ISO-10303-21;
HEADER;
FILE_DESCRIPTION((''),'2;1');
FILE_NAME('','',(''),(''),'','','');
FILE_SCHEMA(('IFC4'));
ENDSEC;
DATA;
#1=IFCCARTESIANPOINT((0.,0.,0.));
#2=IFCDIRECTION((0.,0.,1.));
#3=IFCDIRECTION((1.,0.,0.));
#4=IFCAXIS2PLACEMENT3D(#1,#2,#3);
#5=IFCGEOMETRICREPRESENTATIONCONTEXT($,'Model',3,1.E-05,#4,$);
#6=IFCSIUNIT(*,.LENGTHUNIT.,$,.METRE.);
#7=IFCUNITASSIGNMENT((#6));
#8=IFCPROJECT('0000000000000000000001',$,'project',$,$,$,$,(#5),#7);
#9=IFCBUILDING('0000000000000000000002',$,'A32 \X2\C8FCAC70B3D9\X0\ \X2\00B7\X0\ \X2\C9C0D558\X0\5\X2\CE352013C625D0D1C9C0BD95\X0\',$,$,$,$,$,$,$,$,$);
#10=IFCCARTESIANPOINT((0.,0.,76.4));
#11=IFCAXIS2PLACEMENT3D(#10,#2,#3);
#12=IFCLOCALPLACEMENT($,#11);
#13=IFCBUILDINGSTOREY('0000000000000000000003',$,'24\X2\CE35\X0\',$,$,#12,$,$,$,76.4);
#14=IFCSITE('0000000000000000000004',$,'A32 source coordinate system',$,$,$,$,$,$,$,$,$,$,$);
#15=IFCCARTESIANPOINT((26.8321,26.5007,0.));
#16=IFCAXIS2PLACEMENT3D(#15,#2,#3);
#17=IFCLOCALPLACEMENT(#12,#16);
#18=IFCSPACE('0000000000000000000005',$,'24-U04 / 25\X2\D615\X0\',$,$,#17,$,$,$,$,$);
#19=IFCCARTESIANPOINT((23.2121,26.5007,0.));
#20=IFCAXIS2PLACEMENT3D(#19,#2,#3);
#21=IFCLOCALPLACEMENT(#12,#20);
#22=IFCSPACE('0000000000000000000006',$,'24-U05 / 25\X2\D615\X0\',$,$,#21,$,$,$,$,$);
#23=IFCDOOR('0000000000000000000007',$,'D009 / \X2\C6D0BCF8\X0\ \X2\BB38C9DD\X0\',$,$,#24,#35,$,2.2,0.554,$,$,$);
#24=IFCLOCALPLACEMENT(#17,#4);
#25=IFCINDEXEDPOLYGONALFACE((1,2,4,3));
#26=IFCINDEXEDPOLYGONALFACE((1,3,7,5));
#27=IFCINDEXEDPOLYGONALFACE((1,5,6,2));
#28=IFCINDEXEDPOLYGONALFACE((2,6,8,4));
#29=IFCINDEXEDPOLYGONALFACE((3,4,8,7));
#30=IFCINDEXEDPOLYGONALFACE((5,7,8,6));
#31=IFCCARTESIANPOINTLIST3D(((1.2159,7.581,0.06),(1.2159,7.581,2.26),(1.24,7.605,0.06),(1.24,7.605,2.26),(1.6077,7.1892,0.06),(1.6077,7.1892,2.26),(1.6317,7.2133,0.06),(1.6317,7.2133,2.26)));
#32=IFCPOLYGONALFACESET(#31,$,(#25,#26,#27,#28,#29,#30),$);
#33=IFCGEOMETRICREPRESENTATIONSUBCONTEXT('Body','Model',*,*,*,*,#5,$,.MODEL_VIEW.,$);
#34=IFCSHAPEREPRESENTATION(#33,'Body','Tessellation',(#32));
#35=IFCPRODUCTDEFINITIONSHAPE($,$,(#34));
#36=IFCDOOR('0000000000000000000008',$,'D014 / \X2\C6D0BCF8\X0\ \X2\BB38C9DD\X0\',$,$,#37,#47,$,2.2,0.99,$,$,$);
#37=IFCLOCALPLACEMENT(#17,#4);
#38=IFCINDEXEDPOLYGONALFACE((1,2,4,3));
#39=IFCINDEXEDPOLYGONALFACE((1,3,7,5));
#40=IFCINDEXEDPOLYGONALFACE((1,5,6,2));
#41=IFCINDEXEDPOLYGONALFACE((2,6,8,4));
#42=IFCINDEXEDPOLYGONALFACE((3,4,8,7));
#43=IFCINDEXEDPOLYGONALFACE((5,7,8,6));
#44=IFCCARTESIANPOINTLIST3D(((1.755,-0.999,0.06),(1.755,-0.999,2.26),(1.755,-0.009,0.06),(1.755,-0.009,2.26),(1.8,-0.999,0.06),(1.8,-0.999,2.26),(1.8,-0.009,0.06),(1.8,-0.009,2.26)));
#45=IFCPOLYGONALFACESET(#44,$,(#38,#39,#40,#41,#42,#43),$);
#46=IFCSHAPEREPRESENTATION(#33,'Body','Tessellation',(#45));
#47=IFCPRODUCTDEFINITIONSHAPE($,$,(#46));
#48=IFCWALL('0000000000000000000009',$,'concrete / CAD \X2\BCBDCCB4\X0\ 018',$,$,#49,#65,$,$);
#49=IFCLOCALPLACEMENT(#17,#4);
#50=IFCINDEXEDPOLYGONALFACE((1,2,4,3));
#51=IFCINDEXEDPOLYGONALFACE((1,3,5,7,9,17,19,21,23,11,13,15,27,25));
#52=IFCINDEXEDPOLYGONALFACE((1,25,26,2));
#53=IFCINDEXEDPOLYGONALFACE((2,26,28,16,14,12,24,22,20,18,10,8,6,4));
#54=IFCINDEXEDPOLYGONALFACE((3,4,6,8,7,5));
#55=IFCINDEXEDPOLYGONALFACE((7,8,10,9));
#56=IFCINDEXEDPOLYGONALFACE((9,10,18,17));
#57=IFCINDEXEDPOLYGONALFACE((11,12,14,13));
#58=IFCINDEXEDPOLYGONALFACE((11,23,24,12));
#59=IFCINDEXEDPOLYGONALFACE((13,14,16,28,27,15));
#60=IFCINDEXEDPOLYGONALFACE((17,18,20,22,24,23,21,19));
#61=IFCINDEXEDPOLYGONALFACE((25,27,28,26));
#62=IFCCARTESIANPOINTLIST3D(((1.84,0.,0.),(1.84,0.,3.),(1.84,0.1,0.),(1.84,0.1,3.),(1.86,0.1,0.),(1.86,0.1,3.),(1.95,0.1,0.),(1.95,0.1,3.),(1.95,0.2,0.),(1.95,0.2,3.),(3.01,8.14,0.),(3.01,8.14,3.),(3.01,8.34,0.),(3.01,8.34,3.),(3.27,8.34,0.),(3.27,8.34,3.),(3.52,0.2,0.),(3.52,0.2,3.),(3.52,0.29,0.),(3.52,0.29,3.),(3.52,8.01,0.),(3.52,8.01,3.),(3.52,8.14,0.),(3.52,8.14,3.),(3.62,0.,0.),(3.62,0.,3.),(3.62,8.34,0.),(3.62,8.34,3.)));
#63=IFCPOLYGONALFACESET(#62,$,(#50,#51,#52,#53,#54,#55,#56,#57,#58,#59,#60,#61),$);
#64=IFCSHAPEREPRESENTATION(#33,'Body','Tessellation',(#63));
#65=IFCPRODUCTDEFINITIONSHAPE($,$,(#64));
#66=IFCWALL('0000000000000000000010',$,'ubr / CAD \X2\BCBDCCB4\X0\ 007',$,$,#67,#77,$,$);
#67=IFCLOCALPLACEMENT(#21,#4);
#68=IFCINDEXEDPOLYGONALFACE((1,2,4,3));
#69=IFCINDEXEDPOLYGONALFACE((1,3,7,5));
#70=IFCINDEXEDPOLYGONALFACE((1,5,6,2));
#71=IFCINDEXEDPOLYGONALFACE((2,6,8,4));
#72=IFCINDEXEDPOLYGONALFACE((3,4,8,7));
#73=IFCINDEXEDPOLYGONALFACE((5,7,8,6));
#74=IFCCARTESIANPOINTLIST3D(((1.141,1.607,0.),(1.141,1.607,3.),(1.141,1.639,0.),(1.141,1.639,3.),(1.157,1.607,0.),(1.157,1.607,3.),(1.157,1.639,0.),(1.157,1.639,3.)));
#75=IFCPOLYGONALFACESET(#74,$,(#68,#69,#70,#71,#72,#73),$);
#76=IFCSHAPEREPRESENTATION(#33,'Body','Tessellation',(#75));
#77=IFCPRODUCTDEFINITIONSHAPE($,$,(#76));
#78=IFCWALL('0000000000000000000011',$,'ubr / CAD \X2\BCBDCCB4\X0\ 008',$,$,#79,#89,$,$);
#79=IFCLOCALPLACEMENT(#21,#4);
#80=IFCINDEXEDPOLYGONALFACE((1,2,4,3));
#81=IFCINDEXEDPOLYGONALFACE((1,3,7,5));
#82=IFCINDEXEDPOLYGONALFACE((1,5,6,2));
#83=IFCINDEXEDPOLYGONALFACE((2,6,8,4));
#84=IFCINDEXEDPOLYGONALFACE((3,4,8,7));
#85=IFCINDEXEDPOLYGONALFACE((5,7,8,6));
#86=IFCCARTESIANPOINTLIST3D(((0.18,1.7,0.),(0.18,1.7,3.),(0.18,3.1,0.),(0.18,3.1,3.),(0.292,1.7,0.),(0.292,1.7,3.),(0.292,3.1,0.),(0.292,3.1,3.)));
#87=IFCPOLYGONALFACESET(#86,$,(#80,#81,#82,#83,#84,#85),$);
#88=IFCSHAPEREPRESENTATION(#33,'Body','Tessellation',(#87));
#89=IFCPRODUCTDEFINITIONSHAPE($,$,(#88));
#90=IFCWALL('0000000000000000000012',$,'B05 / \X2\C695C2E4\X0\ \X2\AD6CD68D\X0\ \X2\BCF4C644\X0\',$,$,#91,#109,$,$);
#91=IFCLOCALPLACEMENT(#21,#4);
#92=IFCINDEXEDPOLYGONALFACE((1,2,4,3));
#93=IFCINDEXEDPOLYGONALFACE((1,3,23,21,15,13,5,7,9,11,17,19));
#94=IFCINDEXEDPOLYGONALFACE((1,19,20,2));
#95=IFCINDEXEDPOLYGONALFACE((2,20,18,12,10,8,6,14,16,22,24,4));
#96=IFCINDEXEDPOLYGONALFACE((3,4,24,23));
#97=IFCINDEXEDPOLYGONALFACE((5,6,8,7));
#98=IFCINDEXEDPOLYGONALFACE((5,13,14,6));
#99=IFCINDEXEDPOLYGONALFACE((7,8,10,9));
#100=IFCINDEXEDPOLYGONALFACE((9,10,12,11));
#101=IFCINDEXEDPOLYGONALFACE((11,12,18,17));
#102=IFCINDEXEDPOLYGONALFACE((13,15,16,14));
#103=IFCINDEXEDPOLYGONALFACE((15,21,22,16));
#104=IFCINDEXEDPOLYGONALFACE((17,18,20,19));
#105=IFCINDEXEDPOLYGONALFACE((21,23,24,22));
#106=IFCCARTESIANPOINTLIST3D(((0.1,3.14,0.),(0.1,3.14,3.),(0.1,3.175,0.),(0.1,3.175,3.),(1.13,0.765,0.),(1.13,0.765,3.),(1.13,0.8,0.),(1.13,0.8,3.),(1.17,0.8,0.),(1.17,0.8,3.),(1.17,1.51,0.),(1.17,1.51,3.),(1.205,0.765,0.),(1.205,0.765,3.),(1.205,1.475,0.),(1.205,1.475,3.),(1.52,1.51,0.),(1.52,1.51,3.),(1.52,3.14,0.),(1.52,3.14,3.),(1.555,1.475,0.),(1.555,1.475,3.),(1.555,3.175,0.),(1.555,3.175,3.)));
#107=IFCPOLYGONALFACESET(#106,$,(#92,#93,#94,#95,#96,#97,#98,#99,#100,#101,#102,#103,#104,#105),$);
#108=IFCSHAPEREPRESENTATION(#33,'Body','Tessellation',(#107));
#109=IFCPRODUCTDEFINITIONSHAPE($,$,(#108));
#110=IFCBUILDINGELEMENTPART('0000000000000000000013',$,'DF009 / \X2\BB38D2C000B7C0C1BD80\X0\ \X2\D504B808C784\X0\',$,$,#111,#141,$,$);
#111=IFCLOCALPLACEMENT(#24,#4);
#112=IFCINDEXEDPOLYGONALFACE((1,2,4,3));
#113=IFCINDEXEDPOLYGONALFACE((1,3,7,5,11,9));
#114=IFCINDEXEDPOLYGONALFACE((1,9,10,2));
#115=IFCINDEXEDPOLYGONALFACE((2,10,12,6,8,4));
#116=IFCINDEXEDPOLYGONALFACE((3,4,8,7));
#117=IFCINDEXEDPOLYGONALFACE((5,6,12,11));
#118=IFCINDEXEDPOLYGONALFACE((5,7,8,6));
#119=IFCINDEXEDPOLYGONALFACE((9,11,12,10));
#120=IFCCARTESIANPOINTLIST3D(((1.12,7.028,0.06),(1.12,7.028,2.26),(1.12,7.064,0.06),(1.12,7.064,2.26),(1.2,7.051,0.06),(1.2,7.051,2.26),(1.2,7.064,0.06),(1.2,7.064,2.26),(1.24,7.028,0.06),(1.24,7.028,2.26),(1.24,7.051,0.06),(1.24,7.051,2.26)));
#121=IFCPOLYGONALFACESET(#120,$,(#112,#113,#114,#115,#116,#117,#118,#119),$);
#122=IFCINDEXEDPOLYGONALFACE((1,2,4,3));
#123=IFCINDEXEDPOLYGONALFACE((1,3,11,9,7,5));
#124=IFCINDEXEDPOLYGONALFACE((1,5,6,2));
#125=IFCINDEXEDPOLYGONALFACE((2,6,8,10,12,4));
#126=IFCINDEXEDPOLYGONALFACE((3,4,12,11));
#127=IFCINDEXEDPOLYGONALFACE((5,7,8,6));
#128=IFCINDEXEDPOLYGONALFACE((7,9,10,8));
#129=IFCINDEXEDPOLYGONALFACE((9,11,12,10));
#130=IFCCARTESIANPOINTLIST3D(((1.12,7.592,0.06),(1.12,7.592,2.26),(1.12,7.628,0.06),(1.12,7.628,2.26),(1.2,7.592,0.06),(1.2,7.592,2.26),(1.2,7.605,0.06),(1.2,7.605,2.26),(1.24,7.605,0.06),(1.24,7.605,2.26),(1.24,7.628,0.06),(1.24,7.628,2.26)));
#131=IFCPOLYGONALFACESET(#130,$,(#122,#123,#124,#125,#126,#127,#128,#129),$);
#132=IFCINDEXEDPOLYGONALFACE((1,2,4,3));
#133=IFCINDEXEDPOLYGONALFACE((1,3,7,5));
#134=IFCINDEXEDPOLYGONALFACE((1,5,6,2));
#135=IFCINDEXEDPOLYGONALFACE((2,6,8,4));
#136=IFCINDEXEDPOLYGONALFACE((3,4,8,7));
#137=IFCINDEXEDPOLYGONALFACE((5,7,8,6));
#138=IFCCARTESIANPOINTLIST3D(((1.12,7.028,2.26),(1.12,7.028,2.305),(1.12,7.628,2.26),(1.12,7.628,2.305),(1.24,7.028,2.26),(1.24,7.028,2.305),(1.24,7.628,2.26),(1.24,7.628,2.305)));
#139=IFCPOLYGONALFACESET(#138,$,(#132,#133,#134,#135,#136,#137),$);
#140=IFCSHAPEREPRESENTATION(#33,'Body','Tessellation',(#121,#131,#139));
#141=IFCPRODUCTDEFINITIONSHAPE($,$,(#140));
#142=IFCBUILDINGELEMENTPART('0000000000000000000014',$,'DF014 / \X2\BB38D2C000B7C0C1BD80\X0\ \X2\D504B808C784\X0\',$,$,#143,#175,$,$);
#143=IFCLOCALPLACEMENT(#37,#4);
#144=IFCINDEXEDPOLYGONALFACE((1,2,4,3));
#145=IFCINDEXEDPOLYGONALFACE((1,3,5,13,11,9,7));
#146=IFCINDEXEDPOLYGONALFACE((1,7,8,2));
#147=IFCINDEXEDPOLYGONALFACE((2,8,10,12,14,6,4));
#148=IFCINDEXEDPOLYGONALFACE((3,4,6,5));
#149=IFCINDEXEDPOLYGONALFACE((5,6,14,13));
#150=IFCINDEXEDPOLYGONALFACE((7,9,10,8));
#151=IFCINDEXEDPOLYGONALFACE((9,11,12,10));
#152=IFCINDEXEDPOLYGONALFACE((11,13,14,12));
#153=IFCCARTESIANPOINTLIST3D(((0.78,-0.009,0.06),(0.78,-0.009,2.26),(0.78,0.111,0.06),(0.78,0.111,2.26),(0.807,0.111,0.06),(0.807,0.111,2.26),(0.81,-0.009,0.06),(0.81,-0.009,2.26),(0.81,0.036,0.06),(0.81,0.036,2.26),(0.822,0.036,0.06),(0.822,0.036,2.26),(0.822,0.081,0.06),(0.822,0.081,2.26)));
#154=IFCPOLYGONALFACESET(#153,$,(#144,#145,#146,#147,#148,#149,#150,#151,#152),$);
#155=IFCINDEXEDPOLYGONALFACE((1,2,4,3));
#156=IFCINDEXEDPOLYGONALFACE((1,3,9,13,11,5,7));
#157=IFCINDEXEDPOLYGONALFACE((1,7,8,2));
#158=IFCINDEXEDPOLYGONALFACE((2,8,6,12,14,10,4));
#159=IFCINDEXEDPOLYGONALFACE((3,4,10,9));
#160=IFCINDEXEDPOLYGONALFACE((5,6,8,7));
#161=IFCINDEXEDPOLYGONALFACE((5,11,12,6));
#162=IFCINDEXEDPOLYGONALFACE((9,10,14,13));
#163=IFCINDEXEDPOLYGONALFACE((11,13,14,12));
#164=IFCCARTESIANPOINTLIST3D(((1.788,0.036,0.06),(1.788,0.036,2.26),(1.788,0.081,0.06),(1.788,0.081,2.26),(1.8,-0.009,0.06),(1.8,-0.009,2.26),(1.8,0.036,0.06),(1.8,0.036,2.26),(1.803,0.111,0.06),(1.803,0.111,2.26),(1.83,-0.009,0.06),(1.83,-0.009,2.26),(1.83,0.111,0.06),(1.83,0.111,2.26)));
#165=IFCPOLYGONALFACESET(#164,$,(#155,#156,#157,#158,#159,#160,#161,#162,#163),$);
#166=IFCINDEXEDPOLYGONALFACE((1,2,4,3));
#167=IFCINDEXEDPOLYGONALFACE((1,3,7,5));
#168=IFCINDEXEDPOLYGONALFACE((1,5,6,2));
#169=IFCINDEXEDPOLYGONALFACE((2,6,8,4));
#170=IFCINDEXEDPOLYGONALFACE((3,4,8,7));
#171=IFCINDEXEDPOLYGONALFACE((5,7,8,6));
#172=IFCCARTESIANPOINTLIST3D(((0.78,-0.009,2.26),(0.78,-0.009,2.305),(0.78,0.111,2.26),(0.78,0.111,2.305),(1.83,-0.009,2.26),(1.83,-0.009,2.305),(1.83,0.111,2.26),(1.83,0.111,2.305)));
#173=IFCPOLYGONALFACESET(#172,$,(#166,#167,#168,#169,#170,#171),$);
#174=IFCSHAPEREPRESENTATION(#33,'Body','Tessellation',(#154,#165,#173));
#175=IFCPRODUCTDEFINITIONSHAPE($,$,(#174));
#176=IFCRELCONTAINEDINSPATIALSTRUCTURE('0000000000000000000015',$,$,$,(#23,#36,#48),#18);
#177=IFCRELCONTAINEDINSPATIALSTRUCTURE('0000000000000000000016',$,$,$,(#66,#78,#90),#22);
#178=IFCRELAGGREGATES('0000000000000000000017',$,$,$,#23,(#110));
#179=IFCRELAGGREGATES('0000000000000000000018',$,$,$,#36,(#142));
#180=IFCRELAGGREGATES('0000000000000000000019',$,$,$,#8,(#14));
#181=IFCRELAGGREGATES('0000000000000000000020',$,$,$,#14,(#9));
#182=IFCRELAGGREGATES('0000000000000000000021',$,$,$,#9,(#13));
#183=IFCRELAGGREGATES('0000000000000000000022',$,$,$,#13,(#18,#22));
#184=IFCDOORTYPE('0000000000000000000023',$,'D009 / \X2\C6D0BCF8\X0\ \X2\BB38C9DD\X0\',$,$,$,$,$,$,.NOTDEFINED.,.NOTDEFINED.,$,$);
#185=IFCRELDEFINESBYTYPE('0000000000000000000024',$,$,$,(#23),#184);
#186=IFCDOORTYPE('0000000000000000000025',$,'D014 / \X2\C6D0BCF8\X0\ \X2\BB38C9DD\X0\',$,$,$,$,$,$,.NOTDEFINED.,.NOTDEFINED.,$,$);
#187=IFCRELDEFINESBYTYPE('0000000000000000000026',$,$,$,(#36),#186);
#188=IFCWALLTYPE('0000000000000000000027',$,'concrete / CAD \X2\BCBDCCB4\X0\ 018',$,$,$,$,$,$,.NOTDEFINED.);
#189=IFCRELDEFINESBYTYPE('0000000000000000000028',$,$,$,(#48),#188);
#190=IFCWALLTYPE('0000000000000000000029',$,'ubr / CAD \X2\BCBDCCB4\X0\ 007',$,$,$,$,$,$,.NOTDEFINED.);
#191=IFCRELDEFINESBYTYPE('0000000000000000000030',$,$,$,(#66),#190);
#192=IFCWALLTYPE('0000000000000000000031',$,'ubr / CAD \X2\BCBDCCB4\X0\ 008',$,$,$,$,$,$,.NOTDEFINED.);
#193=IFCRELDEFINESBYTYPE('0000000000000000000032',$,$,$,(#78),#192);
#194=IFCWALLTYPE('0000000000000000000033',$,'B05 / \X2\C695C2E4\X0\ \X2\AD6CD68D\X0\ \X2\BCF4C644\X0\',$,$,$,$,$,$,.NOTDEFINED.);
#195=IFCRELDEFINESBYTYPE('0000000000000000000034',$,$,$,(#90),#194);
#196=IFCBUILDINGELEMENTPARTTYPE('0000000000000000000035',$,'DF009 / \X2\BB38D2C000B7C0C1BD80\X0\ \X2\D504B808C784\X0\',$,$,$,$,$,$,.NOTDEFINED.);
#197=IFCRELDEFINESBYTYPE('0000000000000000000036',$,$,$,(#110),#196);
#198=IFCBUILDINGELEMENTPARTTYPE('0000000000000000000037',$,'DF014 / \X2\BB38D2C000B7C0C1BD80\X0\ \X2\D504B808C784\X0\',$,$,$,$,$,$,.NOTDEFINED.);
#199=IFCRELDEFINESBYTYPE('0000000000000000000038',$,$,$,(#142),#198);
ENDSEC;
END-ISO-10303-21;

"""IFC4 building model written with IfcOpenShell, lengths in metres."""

from ifc_helpers import new_model, si_unit, frame, origin, origin_with_axes, place, context, subcontext, project, spatial, polyline, outline, extrude, source, transform, mapped, type_object, type_shapes, element, aggregate, save


model = new_model("IFC4")

# Units and contexts
model_context = context("Model", 3, precision=1e-05, world=origin_with_axes())
body_context = subcontext(model_context, "Body", "Model", "MODEL_VIEW")
ifc_project = project(units=[si_unit("LENGTHUNIT", "METRE")], contexts=[model_context])

# Site, building, storey, space
storey_placement = place(None, frame((0.0, 0.0, 76.4), z_axis=(0.0, 0.0, 1.0), x_axis=(1.0, 0.0, 0.0)))
space_1_placement = place(storey_placement, frame((26.8321, 26.5007, 0.0), z_axis=(0.0, 0.0, 1.0), x_axis=(1.0, 0.0, 0.0)))
site = spatial("IfcSite", under=ifc_project, Name="A32 source coordinate system")
building = spatial("IfcBuilding", under=site, Name="A32 주거동 · 지하5층–옥탑지붕")
storey = spatial("IfcBuildingStorey", under=building, at=storey_placement, Name="24층", Elevation=76.4)
space_1 = spatial("IfcSpace", under=storey, at=space_1_placement, Name="24-U04 / 25형")

# Doors
door_type_1 = type_object("IfcDoorType", Name="D009 / 원본 문짝", OperationType="NOTDEFINED", PredefinedType="NOTDEFINED")
shared_shape_1 = source(origin(), body_context, "Body", "SweptSolid", [
    extrude(outline(polyline([(1.24, 7.605), (1.6317, 7.2133), (1.6077, 7.1892), (1.2159, 7.581), (1.24, 7.605)])), frame((0.0, 0.0, 0.06)), (0.0, 0.0, 1.0), 2.2),
])
type_shapes(door_type_1, [shared_shape_1])
door_1_placement = place(space_1_placement, origin_with_axes())
door_1 = element("IfcDoor", 1, at=door_1_placement, inside=space_1, type_object=door_type_1, Name="D009 / 원본 문짝", OverallHeight=2.2, OverallWidth=0.554, context=body_context, shape_type="MappedRepresentation", body=[
    mapped(shared_shape_1, transform((0.0, 0.0, 0.0), scale=1.0)),
])
door_type_2 = type_object("IfcDoorType", Name="D014 / 원본 문짝", OperationType="NOTDEFINED", PredefinedType="NOTDEFINED")
shared_shape_2 = source(origin(), body_context, "Body", "SweptSolid", [
    extrude(outline(polyline([(1.8, -0.009), (1.8, -0.999), (1.755, -0.999), (1.755, -0.009), (1.8, -0.009)])), frame((0.0, 0.0, 0.06)), (0.0, 0.0, 1.0), 2.2),
])
type_shapes(door_type_2, [shared_shape_2])
door_2_placement = place(space_1_placement, origin_with_axes())
door_2 = element("IfcDoor", 2, at=door_2_placement, inside=space_1, type_object=door_type_2, Name="D014 / 원본 문짝", OverallHeight=2.2, OverallWidth=0.99, context=body_context, shape_type="MappedRepresentation", body=[
    mapped(shared_shape_2, transform((0.0, 0.0, 0.0), scale=1.0)),
])

# Wall
wall_type_1 = type_object("IfcWallType", Name="concrete / CAD 벽체 018", PredefinedType="NOTDEFINED")
shared_shape_3 = source(origin(), body_context, "Body", "SweptSolid", [
    extrude(outline(polyline([(3.27, 8.34), (3.27, 8.34), (3.62, 8.34), (3.62, 0.0), (1.84, 0.0), (1.84, 0.1), (1.86, 0.1), (1.95, 0.1), (1.95, 0.2), (3.52, 0.2), (3.52, 0.29), (3.52, 8.01), (3.52, 8.14), (3.01, 8.14), (3.01, 8.34), (3.27, 8.34)])), origin(), (0.0, 0.0, 1.0), 3.0),
])
type_shapes(wall_type_1, [shared_shape_3])
wall_1_placement = place(space_1_placement, origin_with_axes())
element("IfcWall", 3, at=wall_1_placement, inside=space_1, type_object=wall_type_1, Name="concrete / CAD 벽체 018", context=body_context, shape_type="MappedRepresentation", body=[
    mapped(shared_shape_3, transform((0.0, 0.0, 0.0), scale=1.0)),
])

# Shared definitions
space_2_placement = place(storey_placement, frame((23.2121, 26.5007, 0.0), z_axis=(0.0, 0.0, 1.0), x_axis=(1.0, 0.0, 0.0)))
space_2 = spatial("IfcSpace", under=storey, at=space_2_placement, Name="24-U05 / 25형")

# Walls
wall_type_2 = type_object("IfcWallType", Name="ubr / CAD 벽체 007", PredefinedType="NOTDEFINED")
shared_shape_4 = source(origin(), body_context, "Body", "SweptSolid", [
    extrude(outline(polyline([(1.157, 1.607), (1.141, 1.607), (1.141, 1.639), (1.157, 1.639), (1.157, 1.607)])), origin(), (0.0, 0.0, 1.0), 3.0),
])
type_shapes(wall_type_2, [shared_shape_4])
wall_2_placement = place(space_2_placement, origin_with_axes())
element("IfcWall", 4, at=wall_2_placement, inside=space_2, type_object=wall_type_2, Name="ubr / CAD 벽체 007", context=body_context, shape_type="MappedRepresentation", body=[
    mapped(shared_shape_4, transform((0.0, 0.0, 0.0), scale=1.0)),
])
wall_type_3 = type_object("IfcWallType", Name="ubr / CAD 벽체 008", PredefinedType="NOTDEFINED")
shared_shape_5 = source(origin(), body_context, "Body", "SweptSolid", [
    extrude(outline(polyline([(0.292, 1.7), (0.18, 1.7), (0.18, 3.1), (0.292, 3.1), (0.292, 1.7)])), origin(), (0.0, 0.0, 1.0), 3.0),
])
type_shapes(wall_type_3, [shared_shape_5])
wall_3_placement = place(space_2_placement, origin_with_axes())
element("IfcWall", 5, at=wall_3_placement, inside=space_2, type_object=wall_type_3, Name="ubr / CAD 벽체 008", context=body_context, shape_type="MappedRepresentation", body=[
    mapped(shared_shape_5, transform((0.0, 0.0, 0.0), scale=1.0)),
])
wall_type_4 = type_object("IfcWallType", Name="B05 / 욕실 구획 보완", PredefinedType="NOTDEFINED")
shared_shape_6 = source(origin(), body_context, "Body", "SweptSolid", [
    extrude(outline(polyline([(1.17, 1.51), (1.52, 1.51), (1.52, 3.14), (0.1, 3.14), (0.1, 3.175), (1.555, 3.175), (1.555, 1.475), (1.205, 1.475), (1.205, 0.765), (1.13, 0.765), (1.13, 0.8), (1.17, 0.8), (1.17, 1.51)])), origin(), (0.0, 0.0, 1.0), 3.0),
])
type_shapes(wall_type_4, [shared_shape_6])
wall_4_placement = place(space_2_placement, origin_with_axes())
element("IfcWall", 6, at=wall_4_placement, inside=space_2, type_object=wall_type_4, Name="B05 / 욕실 구획 보완", context=body_context, shape_type="MappedRepresentation", body=[
    mapped(shared_shape_6, transform((0.0, 0.0, 0.0), scale=1.0)),
])

# Building element parts
building_element_part_type_1 = type_object("IfcBuildingElementPartType", Name="DF009 / 문틀·상부 프레임", PredefinedType="NOTDEFINED")
shared_shape_7 = source(origin(), body_context, "Body", "SweptSolid", [
    extrude(outline(polyline([(1.12, 7.064), (1.2, 7.064), (1.2, 7.051), (1.24, 7.051), (1.24, 7.028), (1.12, 7.028), (1.12, 7.064)])), frame((0.0, 0.0, 0.06)), (0.0, 0.0, 1.0), 2.2),
    extrude(outline(polyline([(1.24, 7.628), (1.24, 7.605), (1.2, 7.605), (1.2, 7.592), (1.12, 7.592), (1.12, 7.628), (1.24, 7.628)])), frame((0.0, 0.0, 0.06)), (0.0, 0.0, 1.0), 2.2),
    extrude(outline(polyline([(1.12, 7.028), (1.12, 7.628), (1.24, 7.628), (1.24, 7.028), (1.12, 7.028)])), frame((0.0, 0.0, 2.26)), (0.0, 0.0, 1.0), 0.045),
])
type_shapes(building_element_part_type_1, [shared_shape_7])
building_element_part_1_placement = place(door_1_placement, origin_with_axes())
building_element_part_1 = element("IfcBuildingElementPart", 7, at=building_element_part_1_placement, type_object=building_element_part_type_1, Name="DF009 / 문틀·상부 프레임", context=body_context, shape_type="MappedRepresentation", body=[
    mapped(shared_shape_7, transform((0.0, 0.0, 0.0), scale=1.0)),
])
aggregate(door_1, [building_element_part_1])
building_element_part_type_2 = type_object("IfcBuildingElementPartType", Name="DF014 / 문틀·상부 프레임", PredefinedType="NOTDEFINED")
shared_shape_8 = source(origin(), body_context, "Body", "SweptSolid", [
    extrude(outline(polyline([(0.78, 0.111), (0.807, 0.111), (0.822, 0.081), (0.822, 0.036), (0.81, 0.036), (0.81, -0.009), (0.78, -0.009), (0.78, 0.111)])), frame((0.0, 0.0, 0.06)), (0.0, 0.0, 1.0), 2.2),
    extrude(outline(polyline([(1.8, -0.009), (1.8, 0.036), (1.788, 0.036), (1.788, 0.081), (1.803, 0.111), (1.83, 0.111), (1.83, -0.009), (1.8, -0.009)])), frame((0.0, 0.0, 0.06)), (0.0, 0.0, 1.0), 2.2),
    extrude(outline(polyline([(0.78, -0.009), (0.78, 0.111), (1.83, 0.111), (1.83, -0.009), (0.78, -0.009)])), frame((0.0, 0.0, 2.26)), (0.0, 0.0, 1.0), 0.045),
])
type_shapes(building_element_part_type_2, [shared_shape_8])
building_element_part_2_placement = place(door_2_placement, origin_with_axes())
building_element_part_2 = element("IfcBuildingElementPart", 8, at=building_element_part_2_placement, type_object=building_element_part_type_2, Name="DF014 / 문틀·상부 프레임", context=body_context, shape_type="MappedRepresentation", body=[
    mapped(shared_shape_8, transform((0.0, 0.0, 0.0), scale=1.0)),
])
aggregate(door_2, [building_element_part_2])

save(model, "model.ifc")
